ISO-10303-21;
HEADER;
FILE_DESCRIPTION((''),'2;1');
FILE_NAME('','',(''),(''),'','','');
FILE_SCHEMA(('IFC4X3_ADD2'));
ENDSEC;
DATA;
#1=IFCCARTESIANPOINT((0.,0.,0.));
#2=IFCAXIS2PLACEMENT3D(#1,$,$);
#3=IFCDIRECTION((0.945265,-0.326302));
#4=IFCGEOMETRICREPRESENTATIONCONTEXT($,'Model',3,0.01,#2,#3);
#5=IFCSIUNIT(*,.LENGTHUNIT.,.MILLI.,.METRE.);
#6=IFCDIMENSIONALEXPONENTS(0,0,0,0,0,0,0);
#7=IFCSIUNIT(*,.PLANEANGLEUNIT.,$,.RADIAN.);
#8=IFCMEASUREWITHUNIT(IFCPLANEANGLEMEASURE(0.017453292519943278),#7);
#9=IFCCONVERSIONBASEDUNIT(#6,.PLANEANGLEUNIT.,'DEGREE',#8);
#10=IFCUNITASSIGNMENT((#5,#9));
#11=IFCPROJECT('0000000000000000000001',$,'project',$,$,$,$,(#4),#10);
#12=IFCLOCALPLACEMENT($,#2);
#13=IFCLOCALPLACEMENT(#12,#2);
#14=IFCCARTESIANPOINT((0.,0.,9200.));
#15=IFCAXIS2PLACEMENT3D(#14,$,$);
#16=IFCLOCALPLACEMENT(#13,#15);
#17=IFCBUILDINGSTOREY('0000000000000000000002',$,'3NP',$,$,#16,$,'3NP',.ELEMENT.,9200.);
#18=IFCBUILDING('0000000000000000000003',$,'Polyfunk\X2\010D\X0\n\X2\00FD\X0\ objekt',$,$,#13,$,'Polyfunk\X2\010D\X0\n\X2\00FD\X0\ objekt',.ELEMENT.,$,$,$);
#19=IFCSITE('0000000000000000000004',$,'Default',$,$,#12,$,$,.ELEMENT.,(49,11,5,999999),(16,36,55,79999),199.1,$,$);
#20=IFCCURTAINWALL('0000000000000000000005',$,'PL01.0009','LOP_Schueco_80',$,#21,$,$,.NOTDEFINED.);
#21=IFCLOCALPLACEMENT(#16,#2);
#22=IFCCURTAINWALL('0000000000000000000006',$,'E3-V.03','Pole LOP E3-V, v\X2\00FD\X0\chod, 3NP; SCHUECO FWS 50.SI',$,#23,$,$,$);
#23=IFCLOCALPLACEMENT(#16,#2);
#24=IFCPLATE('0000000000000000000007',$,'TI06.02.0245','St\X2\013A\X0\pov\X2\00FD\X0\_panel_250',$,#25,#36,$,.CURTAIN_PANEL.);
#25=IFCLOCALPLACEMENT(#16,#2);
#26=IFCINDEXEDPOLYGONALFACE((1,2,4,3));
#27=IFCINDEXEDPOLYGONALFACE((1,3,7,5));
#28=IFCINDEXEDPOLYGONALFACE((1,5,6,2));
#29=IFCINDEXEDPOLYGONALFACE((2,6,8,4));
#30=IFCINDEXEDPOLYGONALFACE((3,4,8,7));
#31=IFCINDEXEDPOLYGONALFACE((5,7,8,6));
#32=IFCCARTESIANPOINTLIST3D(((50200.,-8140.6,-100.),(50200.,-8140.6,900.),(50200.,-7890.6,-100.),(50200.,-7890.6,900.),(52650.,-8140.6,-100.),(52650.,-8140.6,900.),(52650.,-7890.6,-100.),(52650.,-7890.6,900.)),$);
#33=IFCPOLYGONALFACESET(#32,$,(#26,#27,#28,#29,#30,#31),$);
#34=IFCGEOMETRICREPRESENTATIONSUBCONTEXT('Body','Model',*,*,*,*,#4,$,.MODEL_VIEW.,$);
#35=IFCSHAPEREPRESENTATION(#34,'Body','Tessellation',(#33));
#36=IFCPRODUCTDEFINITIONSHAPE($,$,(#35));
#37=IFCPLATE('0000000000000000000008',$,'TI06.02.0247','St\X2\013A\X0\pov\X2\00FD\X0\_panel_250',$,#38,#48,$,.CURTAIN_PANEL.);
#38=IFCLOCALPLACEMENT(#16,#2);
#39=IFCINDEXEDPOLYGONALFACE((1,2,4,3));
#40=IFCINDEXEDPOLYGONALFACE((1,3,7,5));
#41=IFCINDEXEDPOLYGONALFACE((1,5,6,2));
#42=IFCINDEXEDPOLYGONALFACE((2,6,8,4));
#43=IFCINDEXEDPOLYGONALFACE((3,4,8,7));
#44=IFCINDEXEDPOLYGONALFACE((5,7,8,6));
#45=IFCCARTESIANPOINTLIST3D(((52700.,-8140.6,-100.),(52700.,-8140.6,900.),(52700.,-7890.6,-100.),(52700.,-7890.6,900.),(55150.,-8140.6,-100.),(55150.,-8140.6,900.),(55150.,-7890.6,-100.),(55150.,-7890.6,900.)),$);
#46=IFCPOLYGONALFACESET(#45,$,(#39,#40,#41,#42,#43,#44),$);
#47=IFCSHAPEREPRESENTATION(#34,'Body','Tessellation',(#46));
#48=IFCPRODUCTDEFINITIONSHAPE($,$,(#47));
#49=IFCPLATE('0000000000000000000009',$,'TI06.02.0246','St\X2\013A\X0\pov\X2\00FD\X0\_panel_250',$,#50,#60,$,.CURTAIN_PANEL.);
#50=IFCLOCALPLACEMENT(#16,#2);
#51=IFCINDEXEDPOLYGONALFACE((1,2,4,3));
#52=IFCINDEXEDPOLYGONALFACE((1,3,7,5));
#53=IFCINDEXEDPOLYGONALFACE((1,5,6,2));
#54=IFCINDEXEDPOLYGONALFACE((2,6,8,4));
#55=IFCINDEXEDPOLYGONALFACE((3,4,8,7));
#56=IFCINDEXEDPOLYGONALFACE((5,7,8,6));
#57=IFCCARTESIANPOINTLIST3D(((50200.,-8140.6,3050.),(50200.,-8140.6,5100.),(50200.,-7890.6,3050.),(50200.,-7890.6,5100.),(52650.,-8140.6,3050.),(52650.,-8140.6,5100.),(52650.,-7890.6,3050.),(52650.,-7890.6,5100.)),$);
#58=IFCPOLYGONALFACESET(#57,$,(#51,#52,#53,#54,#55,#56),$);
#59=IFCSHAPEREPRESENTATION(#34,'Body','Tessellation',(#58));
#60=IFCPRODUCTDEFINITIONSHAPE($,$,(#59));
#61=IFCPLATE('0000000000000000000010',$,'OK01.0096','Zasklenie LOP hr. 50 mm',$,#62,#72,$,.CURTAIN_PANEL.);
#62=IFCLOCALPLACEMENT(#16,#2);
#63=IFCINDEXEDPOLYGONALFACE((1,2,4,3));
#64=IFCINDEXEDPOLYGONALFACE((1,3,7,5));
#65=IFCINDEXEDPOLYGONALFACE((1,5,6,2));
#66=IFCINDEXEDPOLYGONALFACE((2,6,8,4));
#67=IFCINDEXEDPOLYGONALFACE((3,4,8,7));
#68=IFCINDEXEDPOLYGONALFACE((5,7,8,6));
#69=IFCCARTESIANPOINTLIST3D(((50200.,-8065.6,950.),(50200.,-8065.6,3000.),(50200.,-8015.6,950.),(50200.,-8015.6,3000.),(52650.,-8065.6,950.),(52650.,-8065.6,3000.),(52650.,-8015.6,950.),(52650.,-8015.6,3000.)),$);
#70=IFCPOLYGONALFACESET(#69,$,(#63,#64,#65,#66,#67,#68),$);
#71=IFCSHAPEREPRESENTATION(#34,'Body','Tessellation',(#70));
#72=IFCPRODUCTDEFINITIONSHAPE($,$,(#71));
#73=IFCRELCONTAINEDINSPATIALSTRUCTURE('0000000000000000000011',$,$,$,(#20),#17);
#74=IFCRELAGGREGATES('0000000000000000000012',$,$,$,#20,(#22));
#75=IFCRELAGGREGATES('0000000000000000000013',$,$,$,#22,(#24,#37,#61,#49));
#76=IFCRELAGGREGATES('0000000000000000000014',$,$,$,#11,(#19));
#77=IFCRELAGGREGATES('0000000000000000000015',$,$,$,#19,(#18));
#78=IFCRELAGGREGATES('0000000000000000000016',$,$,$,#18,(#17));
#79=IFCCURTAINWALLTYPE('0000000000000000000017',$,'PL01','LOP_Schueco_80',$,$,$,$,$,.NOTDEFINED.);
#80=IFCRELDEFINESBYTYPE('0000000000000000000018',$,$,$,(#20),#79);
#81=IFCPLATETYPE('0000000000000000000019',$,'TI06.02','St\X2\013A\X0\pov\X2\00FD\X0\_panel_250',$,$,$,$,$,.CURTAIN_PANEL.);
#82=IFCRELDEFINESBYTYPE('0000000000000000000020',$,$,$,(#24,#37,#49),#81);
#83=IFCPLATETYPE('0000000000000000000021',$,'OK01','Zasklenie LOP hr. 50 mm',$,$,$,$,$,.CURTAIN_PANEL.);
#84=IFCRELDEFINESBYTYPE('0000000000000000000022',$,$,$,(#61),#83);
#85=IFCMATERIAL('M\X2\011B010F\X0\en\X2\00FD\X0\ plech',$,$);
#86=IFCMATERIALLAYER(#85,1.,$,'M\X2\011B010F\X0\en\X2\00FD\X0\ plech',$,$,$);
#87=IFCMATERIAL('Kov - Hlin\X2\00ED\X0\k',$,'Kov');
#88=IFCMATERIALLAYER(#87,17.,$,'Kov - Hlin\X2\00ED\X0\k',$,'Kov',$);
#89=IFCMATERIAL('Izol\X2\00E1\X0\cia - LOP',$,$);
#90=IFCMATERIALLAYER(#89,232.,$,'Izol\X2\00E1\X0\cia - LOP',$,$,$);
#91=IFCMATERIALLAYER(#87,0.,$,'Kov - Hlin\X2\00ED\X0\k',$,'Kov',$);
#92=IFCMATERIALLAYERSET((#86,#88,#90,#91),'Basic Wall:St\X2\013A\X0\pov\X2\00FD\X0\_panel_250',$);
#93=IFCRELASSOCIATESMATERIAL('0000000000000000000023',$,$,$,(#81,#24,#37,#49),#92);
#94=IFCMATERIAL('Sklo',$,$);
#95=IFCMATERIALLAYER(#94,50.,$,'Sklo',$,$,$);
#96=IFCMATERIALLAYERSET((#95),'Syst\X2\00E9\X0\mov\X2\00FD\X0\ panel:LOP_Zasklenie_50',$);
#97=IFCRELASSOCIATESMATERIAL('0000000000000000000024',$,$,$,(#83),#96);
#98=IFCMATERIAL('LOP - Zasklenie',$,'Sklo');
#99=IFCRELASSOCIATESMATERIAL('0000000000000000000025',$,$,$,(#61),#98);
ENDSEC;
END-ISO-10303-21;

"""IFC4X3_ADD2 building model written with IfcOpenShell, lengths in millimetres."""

from ifc_helpers import new_model, entity, si_unit, converted_unit, direction, frame, frame_2d, origin, origin_2d_with_axis, place, context, subcontext, project, spatial, rectangle, extrude, source, transform, mapped, material, layer, layer_set, layer_usage, type_object, type_shapes, element, aggregate, save


model = new_model("IFC4X3_ADD2")

# Units and contexts
model_context = context("Model", 3, precision=0.01, world=origin(), true_north=direction((0.945265, -0.326302)))
body_context = subcontext(model_context, "Body", "Model", "MODEL_VIEW")
ifc_project = project(units=[si_unit("LENGTHUNIT", "METRE", prefix="MILLI"), converted_unit("PLANEANGLEUNIT", "DEGREE", entity("IfcPlaneAngleMeasure", 0.017453292519943278), si_unit("PLANEANGLEUNIT", "RADIAN"), dimensions=[0, 0, 0, 0, 0, 0, 0])], contexts=[model_context])

# Site, building, storey
site_placement = place(None, origin())
site = spatial("IfcSite", under=ifc_project, at=site_placement, Name="Default", CompositionType="ELEMENT", RefLatitude=(49, 11, 5, 999999), RefLongitude=(16, 36, 55, 79999), RefElevation=199.1)
building_placement = place(site_placement, origin())
building = spatial("IfcBuilding", under=site, at=building_placement, Name="Polyfunkčný objekt", LongName="Polyfunkčný objekt", CompositionType="ELEMENT")
storey_placement = place(building_placement, frame((0.0, 0.0, 9200.0)))
storey = spatial("IfcBuildingStorey", under=building, at=storey_placement, Name="3NP", LongName="3NP", CompositionType="ELEMENT", Elevation=9200.0)

# Curtain walls, plates
curtain_wall_type = type_object("IfcCurtainWallType", Name="PL01", Description="LOP_Schueco_80", PredefinedType="NOTDEFINED")
curtain_wall_1_placement = place(storey_placement, frame((0.0, 0.0, -9200.0)))
curtain_wall_1 = element("IfcCurtainWall", 1, at=curtain_wall_1_placement, inside=storey, type_object=curtain_wall_type, Name="PL01.0009", Description="LOP_Schueco_80", PredefinedType="NOTDEFINED")
curtain_wall_2 = element("IfcCurtainWall", 2, Name="E3-V.03", Description="Pole LOP E3-V, východ, 3NP; SCHUECO FWS 50.SI")
aggregate(curtain_wall_1, [curtain_wall_2])
ifc_material_1 = material(Name="Měďený plech")
ifc_layer_1 = layer(ifc_material_1, 1.0, Name="Měďený plech")
ifc_material_2 = material(Name="Kov - Hliník", Category="Kov")
ifc_layer_2 = layer(ifc_material_2, 17.0, Name="Kov - Hliník", Category="Kov")
ifc_material_3 = material(Name="Izolácia - LOP")
ifc_layer_3 = layer(ifc_material_3, 232.0, Name="Izolácia - LOP")
ifc_layer_4 = layer(ifc_material_2, 0.0, Name="Kov - Hliník", Category="Kov")
ifc_layer_set_1 = layer_set([ifc_layer_1, ifc_layer_2, ifc_layer_3, ifc_layer_4], Name="Basic Wall:Stĺpový_panel_250")
ifc_layer_usage_1 = layer_usage(ifc_layer_set_1, "AXIS2", "POSITIVE", -125.0)
plate_type_1 = type_object("IfcPlateType", Name="TI06.02", Description="Stĺpový_panel_250", PredefinedType="CURTAIN_PANEL", material=ifc_layer_set_1)
plate_1_placement = place(storey_placement, frame((50200.0, -8015.6, -100.0)))
plate_1 = element("IfcPlate", 3, at=plate_1_placement, type_object=plate_type_1, material=ifc_layer_usage_1, Name="TI06.02.0245", Description="Stĺpový_panel_250", PredefinedType="CURTAIN_PANEL", context=body_context, shape_type="SweptSolid", body=[
    extrude(rectangle(XDim=250.0, YDim=2450.0, at=origin_2d_with_axis()), frame((1225.0, 0.0, 0.0), z_axis=(0.0, 0.0, 1.0), x_axis=(0.0, 1.0, 0.0)), (0.0, 0.0, 1.0), 1000.0),
])
ifc_layer_usage_2 = layer_usage(ifc_layer_set_1, "AXIS2", "POSITIVE", -125.0)
plate_2_placement = place(storey_placement, frame((52700.0, -8015.6, -100.0)))
plate_2 = element("IfcPlate", 4, at=plate_2_placement, type_object=plate_type_1, material=ifc_layer_usage_2, Name="TI06.02.0247", Description="Stĺpový_panel_250", PredefinedType="CURTAIN_PANEL", context=body_context, shape_type="SweptSolid", body=[
    extrude(rectangle(XDim=250.0, YDim=2450.0, at=frame_2d((0.0, 0.0), x_axis=(1.0, 0.0))), frame((1225.0, 0.0, 0.0), z_axis=(0.0, 0.0, 1.0), x_axis=(0.0, 1.0, 0.0)), (0.0, 0.0, 1.0), 1000.0),
])
ifc_layer_usage_3 = layer_usage(ifc_layer_set_1, "AXIS2", "POSITIVE", -125.0)
plate_3_placement = place(storey_placement, frame((50200.0, -8015.6, 3050.0)))
plate_3 = element("IfcPlate", 5, at=plate_3_placement, type_object=plate_type_1, material=ifc_layer_usage_3, Name="TI06.02.0246", Description="Stĺpový_panel_250", PredefinedType="CURTAIN_PANEL", context=body_context, shape_type="SweptSolid", body=[
    extrude(rectangle(XDim=250.0, YDim=2450.0, at=origin_2d_with_axis()), frame((1225.0, 0.0, 0.0), z_axis=(0.0, 0.0, 1.0), x_axis=(0.0, 1.0, 0.0)), (0.0, 0.0, 1.0), 2050.0),
])
ifc_material_4 = material(Name="LOP - Zasklenie", Category="Sklo")
ifc_material_5 = material(Name="Sklo")
ifc_layer_5 = layer(ifc_material_5, 50.0, Name="Sklo")
ifc_layer_set_2 = layer_set([ifc_layer_5], Name="Systémový panel:LOP_Zasklenie_50")
plate_type_2 = type_object("IfcPlateType", Name="OK01", Description="Zasklenie LOP hr. 50 mm", PredefinedType="CURTAIN_PANEL", material=ifc_layer_set_2)
shared_shape_1 = source(origin(), body_context, "Body", "SweptSolid", [
    extrude(rectangle(XDim=50.0, YDim=2450.0, at=origin_2d_with_axis()), frame((0.0, -25.0, 0.0), z_axis=(0.0, 0.0, 1.0), x_axis=(0.0, 1.0, 0.0)), (0.0, 0.0, 1.0), 2050.0),
])
type_shapes(plate_type_2, [shared_shape_1])
plate_4_placement = place(curtain_wall_1_placement, frame((51425.0, -8015.6, 10150.0)))
plate_4 = element("IfcPlate", 6, at=plate_4_placement, type_object=plate_type_2, material=ifc_material_4, Name="OK01.0096", Description="Zasklenie LOP hr. 50 mm", PredefinedType="CURTAIN_PANEL", context=body_context, shape_type="MappedRepresentation", body=[
    mapped(shared_shape_1, transform((0.0, 0.0, 0.0), scale=1.0)),
])
aggregate(curtain_wall_2, [plate_1, plate_2, plate_4, plate_3])

save(model, "model.ifc")
